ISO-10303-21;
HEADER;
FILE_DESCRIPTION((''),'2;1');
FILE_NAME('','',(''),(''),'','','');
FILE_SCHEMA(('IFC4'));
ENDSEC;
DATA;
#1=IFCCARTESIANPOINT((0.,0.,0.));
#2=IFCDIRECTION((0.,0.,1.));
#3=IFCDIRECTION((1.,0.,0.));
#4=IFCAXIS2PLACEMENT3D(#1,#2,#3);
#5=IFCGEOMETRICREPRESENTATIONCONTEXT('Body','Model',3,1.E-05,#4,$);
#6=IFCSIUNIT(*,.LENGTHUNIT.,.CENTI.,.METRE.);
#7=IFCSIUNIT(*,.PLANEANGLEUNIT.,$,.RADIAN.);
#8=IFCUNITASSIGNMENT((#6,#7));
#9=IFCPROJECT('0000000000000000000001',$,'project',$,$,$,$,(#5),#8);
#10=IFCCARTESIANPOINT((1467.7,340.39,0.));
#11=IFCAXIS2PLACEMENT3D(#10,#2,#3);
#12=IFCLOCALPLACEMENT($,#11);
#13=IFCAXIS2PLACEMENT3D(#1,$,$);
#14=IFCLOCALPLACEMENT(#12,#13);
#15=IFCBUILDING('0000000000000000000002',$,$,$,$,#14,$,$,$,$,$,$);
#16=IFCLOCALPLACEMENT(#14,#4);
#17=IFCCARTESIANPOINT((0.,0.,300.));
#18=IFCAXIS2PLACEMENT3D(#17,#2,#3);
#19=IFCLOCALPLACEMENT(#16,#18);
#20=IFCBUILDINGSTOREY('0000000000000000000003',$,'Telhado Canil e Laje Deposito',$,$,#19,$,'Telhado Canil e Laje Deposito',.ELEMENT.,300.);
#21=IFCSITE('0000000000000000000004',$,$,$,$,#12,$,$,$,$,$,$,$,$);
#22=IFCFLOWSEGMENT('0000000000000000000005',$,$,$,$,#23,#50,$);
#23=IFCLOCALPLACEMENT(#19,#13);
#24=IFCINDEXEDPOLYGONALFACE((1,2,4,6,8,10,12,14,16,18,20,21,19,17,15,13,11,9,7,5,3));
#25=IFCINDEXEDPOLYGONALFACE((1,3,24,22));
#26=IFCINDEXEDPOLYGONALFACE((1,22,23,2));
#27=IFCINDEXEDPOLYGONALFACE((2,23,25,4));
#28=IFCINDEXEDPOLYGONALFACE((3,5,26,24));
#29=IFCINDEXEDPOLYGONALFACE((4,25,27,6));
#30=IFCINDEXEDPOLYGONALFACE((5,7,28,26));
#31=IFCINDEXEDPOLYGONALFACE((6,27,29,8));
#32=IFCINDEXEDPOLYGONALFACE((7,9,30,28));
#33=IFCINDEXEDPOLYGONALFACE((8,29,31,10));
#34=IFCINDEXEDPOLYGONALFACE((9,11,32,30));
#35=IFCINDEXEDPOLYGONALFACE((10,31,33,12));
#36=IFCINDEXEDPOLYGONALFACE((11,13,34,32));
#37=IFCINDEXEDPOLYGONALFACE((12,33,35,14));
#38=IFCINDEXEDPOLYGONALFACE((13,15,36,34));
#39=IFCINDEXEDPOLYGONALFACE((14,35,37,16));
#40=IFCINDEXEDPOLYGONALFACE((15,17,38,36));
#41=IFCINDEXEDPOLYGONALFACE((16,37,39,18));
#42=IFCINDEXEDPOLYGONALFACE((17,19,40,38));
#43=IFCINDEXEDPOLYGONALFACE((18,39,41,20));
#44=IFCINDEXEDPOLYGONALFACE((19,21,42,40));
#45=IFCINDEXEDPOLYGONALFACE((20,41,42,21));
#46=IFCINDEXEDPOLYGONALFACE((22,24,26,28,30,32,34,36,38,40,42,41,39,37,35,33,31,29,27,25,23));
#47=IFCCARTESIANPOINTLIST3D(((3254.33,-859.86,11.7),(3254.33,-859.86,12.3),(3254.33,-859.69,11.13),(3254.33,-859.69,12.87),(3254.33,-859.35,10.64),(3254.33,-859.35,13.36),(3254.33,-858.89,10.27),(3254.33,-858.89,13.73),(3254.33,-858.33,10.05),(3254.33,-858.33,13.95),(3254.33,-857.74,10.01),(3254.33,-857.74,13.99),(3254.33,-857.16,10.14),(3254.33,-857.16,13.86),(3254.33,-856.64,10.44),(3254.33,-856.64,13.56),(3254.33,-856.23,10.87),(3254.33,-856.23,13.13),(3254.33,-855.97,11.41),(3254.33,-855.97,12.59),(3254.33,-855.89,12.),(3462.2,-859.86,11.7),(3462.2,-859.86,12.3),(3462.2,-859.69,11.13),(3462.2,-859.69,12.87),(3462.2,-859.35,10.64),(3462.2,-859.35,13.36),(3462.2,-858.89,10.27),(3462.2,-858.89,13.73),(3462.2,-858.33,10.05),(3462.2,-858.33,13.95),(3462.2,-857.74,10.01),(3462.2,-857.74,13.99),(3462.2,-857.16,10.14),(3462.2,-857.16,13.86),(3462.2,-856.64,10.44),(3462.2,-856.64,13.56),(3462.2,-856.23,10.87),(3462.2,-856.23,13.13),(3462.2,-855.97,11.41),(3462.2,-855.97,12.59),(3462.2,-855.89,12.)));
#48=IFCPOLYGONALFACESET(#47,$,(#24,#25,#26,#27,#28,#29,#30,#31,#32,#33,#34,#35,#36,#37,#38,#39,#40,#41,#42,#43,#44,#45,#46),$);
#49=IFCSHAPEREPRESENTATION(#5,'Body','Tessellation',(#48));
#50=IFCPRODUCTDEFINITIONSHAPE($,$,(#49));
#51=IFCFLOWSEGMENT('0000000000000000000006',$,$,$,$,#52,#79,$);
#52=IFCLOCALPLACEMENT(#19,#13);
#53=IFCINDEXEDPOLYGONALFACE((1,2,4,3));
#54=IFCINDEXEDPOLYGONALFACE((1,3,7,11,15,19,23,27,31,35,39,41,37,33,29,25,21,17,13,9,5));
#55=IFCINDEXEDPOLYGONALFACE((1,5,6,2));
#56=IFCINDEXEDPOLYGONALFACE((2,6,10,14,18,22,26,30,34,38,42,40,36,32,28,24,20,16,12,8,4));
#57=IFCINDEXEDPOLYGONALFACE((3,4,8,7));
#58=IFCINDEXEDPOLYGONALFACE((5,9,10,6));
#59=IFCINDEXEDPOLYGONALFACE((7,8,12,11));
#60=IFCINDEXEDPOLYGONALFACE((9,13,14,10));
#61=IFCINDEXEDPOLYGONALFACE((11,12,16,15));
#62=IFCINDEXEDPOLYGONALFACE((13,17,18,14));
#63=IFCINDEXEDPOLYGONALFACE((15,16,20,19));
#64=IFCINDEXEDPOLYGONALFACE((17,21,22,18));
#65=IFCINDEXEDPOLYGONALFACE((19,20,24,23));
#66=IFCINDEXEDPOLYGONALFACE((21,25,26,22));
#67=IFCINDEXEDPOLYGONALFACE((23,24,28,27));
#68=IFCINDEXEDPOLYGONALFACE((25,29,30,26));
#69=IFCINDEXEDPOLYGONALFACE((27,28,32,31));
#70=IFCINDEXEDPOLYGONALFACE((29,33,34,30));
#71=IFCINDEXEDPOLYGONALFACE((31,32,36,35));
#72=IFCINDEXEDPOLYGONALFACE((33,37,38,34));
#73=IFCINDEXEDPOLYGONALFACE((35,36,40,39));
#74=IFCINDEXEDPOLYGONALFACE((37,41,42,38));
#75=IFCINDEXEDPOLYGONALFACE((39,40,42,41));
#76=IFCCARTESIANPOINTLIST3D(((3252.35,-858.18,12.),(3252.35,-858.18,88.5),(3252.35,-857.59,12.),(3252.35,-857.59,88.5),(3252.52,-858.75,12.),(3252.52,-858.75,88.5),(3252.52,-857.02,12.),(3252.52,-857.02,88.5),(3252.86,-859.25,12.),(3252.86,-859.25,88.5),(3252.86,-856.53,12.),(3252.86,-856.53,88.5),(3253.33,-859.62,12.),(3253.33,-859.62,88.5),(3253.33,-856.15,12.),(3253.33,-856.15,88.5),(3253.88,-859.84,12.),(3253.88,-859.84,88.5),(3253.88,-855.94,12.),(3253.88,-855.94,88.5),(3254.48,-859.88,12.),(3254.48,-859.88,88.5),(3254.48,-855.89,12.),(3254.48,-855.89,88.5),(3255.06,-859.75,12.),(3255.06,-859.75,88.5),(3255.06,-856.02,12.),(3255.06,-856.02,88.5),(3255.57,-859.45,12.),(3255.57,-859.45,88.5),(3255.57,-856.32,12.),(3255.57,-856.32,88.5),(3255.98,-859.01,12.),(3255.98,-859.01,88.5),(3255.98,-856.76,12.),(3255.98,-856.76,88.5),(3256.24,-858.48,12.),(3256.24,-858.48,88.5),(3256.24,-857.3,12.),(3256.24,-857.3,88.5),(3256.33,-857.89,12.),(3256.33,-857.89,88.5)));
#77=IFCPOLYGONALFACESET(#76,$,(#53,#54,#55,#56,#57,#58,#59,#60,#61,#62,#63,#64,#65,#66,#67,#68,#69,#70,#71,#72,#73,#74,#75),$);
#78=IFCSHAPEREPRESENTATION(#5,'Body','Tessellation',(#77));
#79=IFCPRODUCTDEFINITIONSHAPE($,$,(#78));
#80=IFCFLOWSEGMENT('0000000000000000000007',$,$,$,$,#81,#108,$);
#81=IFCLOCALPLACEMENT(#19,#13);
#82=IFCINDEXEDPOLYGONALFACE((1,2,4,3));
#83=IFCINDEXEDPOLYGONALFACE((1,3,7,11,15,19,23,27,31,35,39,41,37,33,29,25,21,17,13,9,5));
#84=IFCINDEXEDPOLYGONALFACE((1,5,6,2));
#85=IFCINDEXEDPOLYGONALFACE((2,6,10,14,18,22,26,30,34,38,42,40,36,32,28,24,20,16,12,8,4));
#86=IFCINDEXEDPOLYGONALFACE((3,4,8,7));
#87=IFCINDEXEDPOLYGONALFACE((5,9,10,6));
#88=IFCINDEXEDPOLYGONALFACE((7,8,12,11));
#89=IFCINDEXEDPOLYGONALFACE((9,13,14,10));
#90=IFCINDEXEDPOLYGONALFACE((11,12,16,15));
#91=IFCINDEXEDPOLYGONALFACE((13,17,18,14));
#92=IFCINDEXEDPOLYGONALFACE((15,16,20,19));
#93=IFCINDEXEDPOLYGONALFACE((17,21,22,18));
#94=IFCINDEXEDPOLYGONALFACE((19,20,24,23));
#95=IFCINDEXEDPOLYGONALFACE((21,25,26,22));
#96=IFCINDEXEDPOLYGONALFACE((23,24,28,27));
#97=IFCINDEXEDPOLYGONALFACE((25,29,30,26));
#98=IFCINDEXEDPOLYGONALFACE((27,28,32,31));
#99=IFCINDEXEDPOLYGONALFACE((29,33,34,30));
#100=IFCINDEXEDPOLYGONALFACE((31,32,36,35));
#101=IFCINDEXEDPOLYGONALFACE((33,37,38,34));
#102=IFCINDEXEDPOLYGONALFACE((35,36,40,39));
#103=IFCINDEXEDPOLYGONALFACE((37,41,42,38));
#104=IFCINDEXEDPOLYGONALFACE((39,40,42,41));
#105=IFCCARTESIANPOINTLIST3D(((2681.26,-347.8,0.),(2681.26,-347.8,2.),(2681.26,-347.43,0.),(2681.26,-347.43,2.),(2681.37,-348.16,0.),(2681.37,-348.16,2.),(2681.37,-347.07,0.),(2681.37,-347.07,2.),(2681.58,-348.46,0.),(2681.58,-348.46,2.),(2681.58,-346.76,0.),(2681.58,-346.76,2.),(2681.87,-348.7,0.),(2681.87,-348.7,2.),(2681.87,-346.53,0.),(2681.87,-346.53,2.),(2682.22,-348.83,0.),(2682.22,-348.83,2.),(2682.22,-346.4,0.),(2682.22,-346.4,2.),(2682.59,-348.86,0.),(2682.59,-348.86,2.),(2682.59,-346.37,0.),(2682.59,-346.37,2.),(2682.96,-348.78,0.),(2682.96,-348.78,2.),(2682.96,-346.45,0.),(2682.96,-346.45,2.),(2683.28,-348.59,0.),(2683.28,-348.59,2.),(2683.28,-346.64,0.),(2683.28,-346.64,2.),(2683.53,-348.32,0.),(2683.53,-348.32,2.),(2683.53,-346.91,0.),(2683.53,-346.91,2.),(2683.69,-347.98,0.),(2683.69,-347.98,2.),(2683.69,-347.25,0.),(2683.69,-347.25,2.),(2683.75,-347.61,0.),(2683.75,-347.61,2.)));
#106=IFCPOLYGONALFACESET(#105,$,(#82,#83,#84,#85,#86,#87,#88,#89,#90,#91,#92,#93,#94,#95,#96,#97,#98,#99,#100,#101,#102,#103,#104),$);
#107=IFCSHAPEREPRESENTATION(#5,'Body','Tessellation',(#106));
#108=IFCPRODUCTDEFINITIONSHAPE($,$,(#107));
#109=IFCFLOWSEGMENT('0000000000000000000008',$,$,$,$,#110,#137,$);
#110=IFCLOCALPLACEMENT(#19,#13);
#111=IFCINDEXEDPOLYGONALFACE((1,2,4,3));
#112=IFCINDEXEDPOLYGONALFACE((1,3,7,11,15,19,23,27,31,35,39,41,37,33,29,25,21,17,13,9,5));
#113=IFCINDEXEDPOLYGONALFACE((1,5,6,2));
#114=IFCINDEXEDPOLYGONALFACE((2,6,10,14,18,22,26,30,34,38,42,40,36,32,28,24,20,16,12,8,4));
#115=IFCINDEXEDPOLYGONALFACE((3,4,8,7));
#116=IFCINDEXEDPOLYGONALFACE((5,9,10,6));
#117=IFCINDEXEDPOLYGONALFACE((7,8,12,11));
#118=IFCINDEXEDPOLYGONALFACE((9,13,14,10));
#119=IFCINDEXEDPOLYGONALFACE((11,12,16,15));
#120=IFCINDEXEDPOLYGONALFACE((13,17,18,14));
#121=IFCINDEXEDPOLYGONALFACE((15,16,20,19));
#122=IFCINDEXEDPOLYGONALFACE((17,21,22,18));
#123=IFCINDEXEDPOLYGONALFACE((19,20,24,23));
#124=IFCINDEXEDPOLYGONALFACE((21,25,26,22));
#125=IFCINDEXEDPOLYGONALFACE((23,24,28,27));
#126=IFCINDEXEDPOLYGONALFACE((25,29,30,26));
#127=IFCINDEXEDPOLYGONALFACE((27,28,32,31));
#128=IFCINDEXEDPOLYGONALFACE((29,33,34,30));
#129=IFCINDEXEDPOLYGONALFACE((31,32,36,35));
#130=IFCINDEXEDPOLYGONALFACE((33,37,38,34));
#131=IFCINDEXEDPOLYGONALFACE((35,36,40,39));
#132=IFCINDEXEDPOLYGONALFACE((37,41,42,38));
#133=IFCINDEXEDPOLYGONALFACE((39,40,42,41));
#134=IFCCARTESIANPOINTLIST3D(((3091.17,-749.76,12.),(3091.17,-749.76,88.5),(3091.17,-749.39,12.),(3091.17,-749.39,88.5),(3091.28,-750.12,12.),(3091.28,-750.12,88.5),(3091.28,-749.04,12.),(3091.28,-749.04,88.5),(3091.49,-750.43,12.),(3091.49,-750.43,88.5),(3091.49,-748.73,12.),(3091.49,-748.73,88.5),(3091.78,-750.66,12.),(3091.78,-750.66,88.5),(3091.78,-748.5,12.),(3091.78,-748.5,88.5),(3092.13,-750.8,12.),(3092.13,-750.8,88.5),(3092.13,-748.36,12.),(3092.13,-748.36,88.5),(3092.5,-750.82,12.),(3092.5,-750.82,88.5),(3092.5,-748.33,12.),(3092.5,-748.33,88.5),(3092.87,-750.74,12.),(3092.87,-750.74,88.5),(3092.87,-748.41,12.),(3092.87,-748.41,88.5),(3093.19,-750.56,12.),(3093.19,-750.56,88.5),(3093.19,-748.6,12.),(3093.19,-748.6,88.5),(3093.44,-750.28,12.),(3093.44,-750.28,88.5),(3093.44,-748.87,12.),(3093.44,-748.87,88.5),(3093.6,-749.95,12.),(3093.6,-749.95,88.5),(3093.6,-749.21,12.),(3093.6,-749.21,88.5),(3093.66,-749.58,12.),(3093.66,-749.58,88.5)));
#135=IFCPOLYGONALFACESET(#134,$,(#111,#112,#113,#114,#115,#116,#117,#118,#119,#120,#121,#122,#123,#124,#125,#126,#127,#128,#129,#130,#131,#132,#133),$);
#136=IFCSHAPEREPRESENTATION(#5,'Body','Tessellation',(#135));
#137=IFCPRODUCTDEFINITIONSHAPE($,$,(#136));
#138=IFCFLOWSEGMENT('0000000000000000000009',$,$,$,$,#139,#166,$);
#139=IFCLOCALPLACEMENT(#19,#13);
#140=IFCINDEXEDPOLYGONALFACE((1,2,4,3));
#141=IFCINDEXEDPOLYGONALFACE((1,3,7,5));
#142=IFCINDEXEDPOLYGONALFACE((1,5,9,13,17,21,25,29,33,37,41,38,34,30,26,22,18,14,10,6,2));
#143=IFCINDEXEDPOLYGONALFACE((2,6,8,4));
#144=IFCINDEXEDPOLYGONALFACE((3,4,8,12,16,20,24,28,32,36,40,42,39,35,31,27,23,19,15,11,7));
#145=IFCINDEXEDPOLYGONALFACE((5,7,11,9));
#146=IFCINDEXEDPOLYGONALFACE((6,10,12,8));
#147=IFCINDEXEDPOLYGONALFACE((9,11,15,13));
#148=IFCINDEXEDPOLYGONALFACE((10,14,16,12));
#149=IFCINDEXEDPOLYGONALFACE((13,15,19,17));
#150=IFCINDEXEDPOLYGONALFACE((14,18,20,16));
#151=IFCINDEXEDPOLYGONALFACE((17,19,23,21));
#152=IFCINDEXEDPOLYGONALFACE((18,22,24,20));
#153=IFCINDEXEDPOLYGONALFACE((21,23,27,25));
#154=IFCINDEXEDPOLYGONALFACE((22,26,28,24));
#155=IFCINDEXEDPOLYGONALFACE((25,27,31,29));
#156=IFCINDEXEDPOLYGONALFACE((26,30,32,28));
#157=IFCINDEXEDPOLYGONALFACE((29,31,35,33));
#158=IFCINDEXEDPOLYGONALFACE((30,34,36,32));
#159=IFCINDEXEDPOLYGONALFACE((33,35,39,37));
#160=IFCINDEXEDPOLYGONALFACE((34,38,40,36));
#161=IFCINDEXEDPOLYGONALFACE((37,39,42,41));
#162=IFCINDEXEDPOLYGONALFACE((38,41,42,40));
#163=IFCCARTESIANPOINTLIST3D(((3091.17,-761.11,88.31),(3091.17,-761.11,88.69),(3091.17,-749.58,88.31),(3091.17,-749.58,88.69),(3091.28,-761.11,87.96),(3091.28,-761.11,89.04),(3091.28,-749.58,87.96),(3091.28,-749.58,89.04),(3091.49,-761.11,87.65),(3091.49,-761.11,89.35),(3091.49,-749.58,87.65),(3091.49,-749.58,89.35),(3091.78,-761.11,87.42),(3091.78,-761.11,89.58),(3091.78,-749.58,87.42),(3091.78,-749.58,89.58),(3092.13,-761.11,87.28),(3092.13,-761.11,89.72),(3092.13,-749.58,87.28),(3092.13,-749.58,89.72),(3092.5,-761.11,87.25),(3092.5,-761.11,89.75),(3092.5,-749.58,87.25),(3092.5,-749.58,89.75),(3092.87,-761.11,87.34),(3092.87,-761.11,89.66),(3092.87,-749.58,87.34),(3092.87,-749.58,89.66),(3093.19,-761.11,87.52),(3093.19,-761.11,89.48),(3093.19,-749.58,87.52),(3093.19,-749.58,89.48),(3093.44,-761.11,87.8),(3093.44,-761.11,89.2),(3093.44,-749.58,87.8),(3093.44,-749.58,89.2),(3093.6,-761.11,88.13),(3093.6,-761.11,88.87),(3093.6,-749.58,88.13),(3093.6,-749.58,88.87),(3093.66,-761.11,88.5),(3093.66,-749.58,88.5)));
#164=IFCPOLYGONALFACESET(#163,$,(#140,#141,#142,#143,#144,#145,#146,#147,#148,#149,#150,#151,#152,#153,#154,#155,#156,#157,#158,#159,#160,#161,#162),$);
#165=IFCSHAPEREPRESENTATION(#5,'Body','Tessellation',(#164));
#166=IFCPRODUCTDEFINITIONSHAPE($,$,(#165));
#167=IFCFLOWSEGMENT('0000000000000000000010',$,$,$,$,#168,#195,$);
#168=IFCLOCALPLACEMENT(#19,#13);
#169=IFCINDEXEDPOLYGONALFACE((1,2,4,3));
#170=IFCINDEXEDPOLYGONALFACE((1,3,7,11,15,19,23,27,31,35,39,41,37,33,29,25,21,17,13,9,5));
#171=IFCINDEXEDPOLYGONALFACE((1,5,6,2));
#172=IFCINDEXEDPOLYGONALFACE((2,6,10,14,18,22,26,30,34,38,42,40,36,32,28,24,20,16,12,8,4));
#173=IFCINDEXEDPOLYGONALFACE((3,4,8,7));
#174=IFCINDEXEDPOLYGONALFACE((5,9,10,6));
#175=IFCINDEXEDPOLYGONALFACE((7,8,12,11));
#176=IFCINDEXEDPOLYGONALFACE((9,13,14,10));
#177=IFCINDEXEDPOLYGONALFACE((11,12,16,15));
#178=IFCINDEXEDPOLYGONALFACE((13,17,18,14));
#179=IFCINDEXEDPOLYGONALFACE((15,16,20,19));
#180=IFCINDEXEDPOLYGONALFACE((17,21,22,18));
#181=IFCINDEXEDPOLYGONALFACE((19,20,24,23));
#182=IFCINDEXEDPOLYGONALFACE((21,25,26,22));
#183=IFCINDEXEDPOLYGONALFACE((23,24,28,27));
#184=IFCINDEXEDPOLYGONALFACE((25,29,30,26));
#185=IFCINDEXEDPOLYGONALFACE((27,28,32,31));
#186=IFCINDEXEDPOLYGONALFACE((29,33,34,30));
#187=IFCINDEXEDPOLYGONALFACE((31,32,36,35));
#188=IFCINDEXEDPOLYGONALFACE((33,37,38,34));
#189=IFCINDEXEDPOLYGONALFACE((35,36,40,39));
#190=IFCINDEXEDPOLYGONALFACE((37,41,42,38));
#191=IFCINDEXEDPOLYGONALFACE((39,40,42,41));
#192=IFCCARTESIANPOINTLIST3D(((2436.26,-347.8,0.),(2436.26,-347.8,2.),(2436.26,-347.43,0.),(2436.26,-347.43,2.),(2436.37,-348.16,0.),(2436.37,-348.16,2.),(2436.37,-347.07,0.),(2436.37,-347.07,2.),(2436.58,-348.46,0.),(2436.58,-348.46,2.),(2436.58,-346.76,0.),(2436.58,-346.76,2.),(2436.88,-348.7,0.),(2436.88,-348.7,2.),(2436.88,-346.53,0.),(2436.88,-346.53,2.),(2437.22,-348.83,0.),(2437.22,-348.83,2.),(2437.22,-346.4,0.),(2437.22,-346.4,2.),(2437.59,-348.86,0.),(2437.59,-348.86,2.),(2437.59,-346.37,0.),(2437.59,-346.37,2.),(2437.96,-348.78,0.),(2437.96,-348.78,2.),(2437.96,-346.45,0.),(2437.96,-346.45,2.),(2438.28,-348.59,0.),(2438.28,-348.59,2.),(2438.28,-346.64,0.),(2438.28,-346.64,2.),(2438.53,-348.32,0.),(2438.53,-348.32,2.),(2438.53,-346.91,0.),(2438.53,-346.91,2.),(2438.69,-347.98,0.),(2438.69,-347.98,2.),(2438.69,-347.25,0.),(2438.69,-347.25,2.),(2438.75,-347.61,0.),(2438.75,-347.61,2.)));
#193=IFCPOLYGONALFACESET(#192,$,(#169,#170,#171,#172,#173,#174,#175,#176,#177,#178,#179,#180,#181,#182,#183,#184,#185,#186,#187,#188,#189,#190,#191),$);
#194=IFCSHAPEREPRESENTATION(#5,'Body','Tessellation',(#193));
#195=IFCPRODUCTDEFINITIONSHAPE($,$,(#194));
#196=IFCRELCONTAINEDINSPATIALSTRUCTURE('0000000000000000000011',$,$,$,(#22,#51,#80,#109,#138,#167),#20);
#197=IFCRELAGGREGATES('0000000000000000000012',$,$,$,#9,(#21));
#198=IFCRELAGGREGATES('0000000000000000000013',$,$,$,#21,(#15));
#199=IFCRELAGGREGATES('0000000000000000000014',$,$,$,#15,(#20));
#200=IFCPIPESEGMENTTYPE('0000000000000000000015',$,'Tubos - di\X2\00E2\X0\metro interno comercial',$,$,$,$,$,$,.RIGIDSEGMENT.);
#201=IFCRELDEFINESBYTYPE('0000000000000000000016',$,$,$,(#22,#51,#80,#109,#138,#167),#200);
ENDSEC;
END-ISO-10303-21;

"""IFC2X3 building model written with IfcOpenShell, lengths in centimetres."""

from ifc_helpers import new_model, si_unit, frame, origin, origin_with_axes, origin_2d_with_axis, place, context, project, spatial, circle, extrude, type_object, element, save


model = new_model("IFC2X3")

# Units and contexts
model_context = context("Model", 3, precision=1e-05, world=origin_with_axes(), identifier="Body")
ifc_project = project(units=[si_unit("LENGTHUNIT", "METRE", prefix="CENTI"), si_unit("PLANEANGLEUNIT", "RADIAN")], contexts=[model_context])

# Site, building, storey
site_placement = place(None, frame((1467.7, 340.39, 0.0), z_axis=(0.0, 0.0, 1.0), x_axis=(1.0, 0.0, 0.0)))
site = spatial("IfcSite", under=ifc_project, at=site_placement)
building_placement = place(site_placement, origin())
building = spatial("IfcBuilding", under=site, at=building_placement)
placement = place(building_placement, origin_with_axes())
storey_placement = place(placement, frame((0.0, 0.0, 300.0), z_axis=(0.0, 0.0, 1.0), x_axis=(1.0, 0.0, 0.0)))
storey = spatial("IfcBuildingStorey", under=building, at=storey_placement, Name="Telhado Canil e Laje Deposito", LongName="Telhado Canil e Laje Deposito", CompositionType="ELEMENT", Elevation=300.0)

# Flow segments
pipe_segment_type_1 = type_object("IfcPipeSegmentType", Name="Tubos - diâmetro interno comercial", PredefinedType="RIGIDSEGMENT")
flow_segment_1_placement = place(storey_placement, frame((3358.26, -857.89, 14.0), z_axis=(0.0, 0.0, 1.0), x_axis=(1.0, 0.0, 0.0)))
element("IfcFlowSegment", 1, at=flow_segment_1_placement, inside=storey, type_object=pipe_segment_type_1, context=model_context, shape_type="SolidModel", body=[
    extrude(circle(Radius=2.0, at=origin_2d_with_axis()), frame((-103.94, 0.0, -2.0), z_axis=(1.0, 0.0, 0.0), x_axis=(0.0, 1.0, 0.0)), (0.0, 0.0, 1.0), 207.87),
])
flow_segment_2_placement = place(storey_placement, frame((3254.33, -857.89, 88.5), z_axis=(0.0, 0.0, 1.0), x_axis=(1.0, 0.0, 0.0)))
element("IfcFlowSegment", 2, at=flow_segment_2_placement, inside=storey, type_object=pipe_segment_type_1, context=model_context, shape_type="SolidModel", body=[
    extrude(circle(Radius=2.0, at=origin_2d_with_axis()), frame((0.0, 0.0, 0.0), z_axis=(0.0, 0.0, -1.0), x_axis=(1.0, 0.0, 0.0)), (0.0, 0.0, 1.0), 76.5),
])
flow_segment_3_placement = place(storey_placement, frame((2682.5, -347.61, 2.0), z_axis=(0.0, 0.0, 1.0), x_axis=(1.0, 0.0, 0.0)))
element("IfcFlowSegment", 3, at=flow_segment_3_placement, inside=storey, type_object=pipe_segment_type_1, context=model_context, shape_type="SolidModel", body=[
    extrude(circle(Radius=1.25, at=origin_2d_with_axis()), frame((0.0, 0.0, 0.0), z_axis=(0.0, 0.0, -1.0), x_axis=(1.0, 0.0, 0.0)), (0.0, 0.0, 1.0), 2.0),
])
flow_segment_4_placement = place(storey_placement, frame((3092.41, -749.58, 88.5), z_axis=(0.0, 0.0, 1.0), x_axis=(1.0, 0.0, 0.0)))
element("IfcFlowSegment", 4, at=flow_segment_4_placement, inside=storey, type_object=pipe_segment_type_1, context=model_context, shape_type="SolidModel", body=[
    extrude(circle(Radius=1.25, at=origin_2d_with_axis()), frame((0.0, 0.0, -76.5), z_axis=(0.0, 0.0, 1.0), x_axis=(1.0, 0.0, 0.0)), (0.0, 0.0, 1.0), 76.5),
])
flow_segment_5_placement = place(storey_placement, frame((3092.41, -755.34, 89.75), z_axis=(0.0, 0.0, 1.0), x_axis=(1.0, 0.0, 0.0)))
element("IfcFlowSegment", 5, at=flow_segment_5_placement, inside=storey, type_object=pipe_segment_type_1, context=model_context, shape_type="SolidModel", body=[
    extrude(circle(Radius=1.25, at=origin_2d_with_axis()), frame((0.0, 5.76, -1.25), z_axis=(0.0, -1.0, 0.0), x_axis=(1.0, 0.0, 0.0)), (0.0, 0.0, 1.0), 11.53),
])
flow_segment_6_placement = place(storey_placement, frame((2437.5, -347.61, 2.0), z_axis=(0.0, 0.0, 1.0), x_axis=(1.0, 0.0, 0.0)))
element("IfcFlowSegment", 6, at=flow_segment_6_placement, inside=storey, type_object=pipe_segment_type_1, context=model_context, shape_type="SolidModel", body=[
    extrude(circle(Radius=1.25, at=origin_2d_with_axis()), frame((0.0, 0.0, 0.0), z_axis=(0.0, 0.0, -1.0), x_axis=(1.0, 0.0, 0.0)), (0.0, 0.0, 1.0), 2.0),
])

save(model, "model.ifc")
